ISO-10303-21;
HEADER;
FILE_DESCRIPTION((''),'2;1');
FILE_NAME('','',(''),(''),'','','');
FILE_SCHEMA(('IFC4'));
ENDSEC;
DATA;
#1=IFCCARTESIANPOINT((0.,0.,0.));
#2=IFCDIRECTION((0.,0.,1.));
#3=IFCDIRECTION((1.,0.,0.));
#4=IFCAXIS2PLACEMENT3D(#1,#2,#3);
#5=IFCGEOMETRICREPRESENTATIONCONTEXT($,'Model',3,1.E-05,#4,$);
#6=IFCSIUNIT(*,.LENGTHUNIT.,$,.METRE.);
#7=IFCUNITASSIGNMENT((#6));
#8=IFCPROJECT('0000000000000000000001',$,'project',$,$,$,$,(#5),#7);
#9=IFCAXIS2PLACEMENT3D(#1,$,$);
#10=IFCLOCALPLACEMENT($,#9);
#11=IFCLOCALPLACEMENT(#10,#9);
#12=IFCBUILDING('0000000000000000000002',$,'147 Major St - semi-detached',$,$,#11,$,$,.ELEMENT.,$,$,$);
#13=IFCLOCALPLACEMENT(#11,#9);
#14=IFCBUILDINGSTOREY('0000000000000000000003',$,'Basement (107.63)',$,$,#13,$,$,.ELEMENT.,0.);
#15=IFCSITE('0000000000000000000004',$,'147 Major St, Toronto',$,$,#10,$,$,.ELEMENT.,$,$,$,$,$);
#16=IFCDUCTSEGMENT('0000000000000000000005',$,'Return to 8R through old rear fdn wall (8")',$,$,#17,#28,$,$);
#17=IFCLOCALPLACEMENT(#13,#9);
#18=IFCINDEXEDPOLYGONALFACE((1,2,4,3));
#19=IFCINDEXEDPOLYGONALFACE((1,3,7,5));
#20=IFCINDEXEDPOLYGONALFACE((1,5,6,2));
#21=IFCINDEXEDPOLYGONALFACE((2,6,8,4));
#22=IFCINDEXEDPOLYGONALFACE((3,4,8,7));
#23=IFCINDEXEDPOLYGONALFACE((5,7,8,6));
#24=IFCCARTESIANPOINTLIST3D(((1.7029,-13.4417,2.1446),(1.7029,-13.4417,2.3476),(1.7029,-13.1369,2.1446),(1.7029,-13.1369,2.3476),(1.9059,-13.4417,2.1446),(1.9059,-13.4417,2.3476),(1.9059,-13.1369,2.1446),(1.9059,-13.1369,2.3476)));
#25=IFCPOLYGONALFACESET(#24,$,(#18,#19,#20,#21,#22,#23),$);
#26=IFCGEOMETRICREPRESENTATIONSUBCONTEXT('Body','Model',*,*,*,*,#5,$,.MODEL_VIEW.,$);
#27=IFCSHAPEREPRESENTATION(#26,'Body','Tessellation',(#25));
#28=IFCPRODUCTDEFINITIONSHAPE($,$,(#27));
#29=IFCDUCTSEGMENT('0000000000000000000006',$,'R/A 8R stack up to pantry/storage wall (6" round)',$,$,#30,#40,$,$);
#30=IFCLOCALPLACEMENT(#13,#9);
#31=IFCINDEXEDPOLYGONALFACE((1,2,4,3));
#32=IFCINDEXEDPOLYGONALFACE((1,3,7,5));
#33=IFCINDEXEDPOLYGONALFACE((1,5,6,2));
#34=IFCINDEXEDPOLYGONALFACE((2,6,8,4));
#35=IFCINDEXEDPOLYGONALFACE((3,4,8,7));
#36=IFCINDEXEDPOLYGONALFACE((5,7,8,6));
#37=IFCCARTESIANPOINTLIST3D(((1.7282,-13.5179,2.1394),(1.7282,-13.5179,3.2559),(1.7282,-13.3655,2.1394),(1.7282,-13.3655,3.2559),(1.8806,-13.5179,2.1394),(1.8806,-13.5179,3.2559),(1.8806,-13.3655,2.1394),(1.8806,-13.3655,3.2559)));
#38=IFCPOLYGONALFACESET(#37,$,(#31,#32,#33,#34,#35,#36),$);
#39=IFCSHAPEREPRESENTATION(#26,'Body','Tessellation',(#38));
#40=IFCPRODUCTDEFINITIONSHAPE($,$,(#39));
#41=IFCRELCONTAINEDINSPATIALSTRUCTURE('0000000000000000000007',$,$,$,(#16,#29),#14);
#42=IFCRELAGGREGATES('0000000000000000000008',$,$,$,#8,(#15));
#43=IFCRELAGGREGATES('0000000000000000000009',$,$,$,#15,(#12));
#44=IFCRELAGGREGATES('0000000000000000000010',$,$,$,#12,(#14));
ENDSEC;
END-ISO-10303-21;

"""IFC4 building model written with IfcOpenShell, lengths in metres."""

from ifc_helpers import new_model, si_unit, frame, origin, origin_with_axes, place, context, subcontext, project, spatial, rectangle, extrude, element, save


model = new_model("IFC4")

# Units and contexts
model_context = context("Model", 3, precision=1e-05, world=origin_with_axes())
body_context = subcontext(model_context, "Body", "Model", "MODEL_VIEW")
ifc_project = project(units=[si_unit("LENGTHUNIT", "METRE")], contexts=[model_context])

# Site, building, storey
site_placement = place(None, origin())
site = spatial("IfcSite", under=ifc_project, at=site_placement, Name="147 Major St, Toronto", CompositionType="ELEMENT")
building_placement = place(site_placement, origin())
building = spatial("IfcBuilding", under=site, at=building_placement, Name="147 Major St - semi-detached", CompositionType="ELEMENT")
storey_placement = place(building_placement, origin())
storey = spatial("IfcBuildingStorey", under=building, at=storey_placement, Name="Basement (107.63)", CompositionType="ELEMENT", Elevation=0.0)

# Duct segments
duct_segment_1_placement = place(storey_placement, frame((1.8044, -13.2893, 2.1446)))
element("IfcDuctSegment", 1, at=duct_segment_1_placement, inside=storey, Name="Return to 8R through old rear fdn wall (8\")", context=body_context, shape_type="SweptSolid", body=[
    extrude(rectangle(XDim=0.203, YDim=0.3048), origin_with_axes(), (0.0, 0.0, 1.0), 0.203),
])
duct_segment_2_placement = place(storey_placement, frame((1.8044, -13.4417, 2.1394)))
element("IfcDuctSegment", 2, at=duct_segment_2_placement, inside=storey, Name="R/A 8R stack up to pantry/storage wall (6\" round)", context=body_context, shape_type="SweptSolid", body=[
    extrude(rectangle(XDim=0.1524, YDim=0.1524), origin_with_axes(), (0.0, 0.0, 1.0), 1.1165),
])

save(model, "model.ifc")
